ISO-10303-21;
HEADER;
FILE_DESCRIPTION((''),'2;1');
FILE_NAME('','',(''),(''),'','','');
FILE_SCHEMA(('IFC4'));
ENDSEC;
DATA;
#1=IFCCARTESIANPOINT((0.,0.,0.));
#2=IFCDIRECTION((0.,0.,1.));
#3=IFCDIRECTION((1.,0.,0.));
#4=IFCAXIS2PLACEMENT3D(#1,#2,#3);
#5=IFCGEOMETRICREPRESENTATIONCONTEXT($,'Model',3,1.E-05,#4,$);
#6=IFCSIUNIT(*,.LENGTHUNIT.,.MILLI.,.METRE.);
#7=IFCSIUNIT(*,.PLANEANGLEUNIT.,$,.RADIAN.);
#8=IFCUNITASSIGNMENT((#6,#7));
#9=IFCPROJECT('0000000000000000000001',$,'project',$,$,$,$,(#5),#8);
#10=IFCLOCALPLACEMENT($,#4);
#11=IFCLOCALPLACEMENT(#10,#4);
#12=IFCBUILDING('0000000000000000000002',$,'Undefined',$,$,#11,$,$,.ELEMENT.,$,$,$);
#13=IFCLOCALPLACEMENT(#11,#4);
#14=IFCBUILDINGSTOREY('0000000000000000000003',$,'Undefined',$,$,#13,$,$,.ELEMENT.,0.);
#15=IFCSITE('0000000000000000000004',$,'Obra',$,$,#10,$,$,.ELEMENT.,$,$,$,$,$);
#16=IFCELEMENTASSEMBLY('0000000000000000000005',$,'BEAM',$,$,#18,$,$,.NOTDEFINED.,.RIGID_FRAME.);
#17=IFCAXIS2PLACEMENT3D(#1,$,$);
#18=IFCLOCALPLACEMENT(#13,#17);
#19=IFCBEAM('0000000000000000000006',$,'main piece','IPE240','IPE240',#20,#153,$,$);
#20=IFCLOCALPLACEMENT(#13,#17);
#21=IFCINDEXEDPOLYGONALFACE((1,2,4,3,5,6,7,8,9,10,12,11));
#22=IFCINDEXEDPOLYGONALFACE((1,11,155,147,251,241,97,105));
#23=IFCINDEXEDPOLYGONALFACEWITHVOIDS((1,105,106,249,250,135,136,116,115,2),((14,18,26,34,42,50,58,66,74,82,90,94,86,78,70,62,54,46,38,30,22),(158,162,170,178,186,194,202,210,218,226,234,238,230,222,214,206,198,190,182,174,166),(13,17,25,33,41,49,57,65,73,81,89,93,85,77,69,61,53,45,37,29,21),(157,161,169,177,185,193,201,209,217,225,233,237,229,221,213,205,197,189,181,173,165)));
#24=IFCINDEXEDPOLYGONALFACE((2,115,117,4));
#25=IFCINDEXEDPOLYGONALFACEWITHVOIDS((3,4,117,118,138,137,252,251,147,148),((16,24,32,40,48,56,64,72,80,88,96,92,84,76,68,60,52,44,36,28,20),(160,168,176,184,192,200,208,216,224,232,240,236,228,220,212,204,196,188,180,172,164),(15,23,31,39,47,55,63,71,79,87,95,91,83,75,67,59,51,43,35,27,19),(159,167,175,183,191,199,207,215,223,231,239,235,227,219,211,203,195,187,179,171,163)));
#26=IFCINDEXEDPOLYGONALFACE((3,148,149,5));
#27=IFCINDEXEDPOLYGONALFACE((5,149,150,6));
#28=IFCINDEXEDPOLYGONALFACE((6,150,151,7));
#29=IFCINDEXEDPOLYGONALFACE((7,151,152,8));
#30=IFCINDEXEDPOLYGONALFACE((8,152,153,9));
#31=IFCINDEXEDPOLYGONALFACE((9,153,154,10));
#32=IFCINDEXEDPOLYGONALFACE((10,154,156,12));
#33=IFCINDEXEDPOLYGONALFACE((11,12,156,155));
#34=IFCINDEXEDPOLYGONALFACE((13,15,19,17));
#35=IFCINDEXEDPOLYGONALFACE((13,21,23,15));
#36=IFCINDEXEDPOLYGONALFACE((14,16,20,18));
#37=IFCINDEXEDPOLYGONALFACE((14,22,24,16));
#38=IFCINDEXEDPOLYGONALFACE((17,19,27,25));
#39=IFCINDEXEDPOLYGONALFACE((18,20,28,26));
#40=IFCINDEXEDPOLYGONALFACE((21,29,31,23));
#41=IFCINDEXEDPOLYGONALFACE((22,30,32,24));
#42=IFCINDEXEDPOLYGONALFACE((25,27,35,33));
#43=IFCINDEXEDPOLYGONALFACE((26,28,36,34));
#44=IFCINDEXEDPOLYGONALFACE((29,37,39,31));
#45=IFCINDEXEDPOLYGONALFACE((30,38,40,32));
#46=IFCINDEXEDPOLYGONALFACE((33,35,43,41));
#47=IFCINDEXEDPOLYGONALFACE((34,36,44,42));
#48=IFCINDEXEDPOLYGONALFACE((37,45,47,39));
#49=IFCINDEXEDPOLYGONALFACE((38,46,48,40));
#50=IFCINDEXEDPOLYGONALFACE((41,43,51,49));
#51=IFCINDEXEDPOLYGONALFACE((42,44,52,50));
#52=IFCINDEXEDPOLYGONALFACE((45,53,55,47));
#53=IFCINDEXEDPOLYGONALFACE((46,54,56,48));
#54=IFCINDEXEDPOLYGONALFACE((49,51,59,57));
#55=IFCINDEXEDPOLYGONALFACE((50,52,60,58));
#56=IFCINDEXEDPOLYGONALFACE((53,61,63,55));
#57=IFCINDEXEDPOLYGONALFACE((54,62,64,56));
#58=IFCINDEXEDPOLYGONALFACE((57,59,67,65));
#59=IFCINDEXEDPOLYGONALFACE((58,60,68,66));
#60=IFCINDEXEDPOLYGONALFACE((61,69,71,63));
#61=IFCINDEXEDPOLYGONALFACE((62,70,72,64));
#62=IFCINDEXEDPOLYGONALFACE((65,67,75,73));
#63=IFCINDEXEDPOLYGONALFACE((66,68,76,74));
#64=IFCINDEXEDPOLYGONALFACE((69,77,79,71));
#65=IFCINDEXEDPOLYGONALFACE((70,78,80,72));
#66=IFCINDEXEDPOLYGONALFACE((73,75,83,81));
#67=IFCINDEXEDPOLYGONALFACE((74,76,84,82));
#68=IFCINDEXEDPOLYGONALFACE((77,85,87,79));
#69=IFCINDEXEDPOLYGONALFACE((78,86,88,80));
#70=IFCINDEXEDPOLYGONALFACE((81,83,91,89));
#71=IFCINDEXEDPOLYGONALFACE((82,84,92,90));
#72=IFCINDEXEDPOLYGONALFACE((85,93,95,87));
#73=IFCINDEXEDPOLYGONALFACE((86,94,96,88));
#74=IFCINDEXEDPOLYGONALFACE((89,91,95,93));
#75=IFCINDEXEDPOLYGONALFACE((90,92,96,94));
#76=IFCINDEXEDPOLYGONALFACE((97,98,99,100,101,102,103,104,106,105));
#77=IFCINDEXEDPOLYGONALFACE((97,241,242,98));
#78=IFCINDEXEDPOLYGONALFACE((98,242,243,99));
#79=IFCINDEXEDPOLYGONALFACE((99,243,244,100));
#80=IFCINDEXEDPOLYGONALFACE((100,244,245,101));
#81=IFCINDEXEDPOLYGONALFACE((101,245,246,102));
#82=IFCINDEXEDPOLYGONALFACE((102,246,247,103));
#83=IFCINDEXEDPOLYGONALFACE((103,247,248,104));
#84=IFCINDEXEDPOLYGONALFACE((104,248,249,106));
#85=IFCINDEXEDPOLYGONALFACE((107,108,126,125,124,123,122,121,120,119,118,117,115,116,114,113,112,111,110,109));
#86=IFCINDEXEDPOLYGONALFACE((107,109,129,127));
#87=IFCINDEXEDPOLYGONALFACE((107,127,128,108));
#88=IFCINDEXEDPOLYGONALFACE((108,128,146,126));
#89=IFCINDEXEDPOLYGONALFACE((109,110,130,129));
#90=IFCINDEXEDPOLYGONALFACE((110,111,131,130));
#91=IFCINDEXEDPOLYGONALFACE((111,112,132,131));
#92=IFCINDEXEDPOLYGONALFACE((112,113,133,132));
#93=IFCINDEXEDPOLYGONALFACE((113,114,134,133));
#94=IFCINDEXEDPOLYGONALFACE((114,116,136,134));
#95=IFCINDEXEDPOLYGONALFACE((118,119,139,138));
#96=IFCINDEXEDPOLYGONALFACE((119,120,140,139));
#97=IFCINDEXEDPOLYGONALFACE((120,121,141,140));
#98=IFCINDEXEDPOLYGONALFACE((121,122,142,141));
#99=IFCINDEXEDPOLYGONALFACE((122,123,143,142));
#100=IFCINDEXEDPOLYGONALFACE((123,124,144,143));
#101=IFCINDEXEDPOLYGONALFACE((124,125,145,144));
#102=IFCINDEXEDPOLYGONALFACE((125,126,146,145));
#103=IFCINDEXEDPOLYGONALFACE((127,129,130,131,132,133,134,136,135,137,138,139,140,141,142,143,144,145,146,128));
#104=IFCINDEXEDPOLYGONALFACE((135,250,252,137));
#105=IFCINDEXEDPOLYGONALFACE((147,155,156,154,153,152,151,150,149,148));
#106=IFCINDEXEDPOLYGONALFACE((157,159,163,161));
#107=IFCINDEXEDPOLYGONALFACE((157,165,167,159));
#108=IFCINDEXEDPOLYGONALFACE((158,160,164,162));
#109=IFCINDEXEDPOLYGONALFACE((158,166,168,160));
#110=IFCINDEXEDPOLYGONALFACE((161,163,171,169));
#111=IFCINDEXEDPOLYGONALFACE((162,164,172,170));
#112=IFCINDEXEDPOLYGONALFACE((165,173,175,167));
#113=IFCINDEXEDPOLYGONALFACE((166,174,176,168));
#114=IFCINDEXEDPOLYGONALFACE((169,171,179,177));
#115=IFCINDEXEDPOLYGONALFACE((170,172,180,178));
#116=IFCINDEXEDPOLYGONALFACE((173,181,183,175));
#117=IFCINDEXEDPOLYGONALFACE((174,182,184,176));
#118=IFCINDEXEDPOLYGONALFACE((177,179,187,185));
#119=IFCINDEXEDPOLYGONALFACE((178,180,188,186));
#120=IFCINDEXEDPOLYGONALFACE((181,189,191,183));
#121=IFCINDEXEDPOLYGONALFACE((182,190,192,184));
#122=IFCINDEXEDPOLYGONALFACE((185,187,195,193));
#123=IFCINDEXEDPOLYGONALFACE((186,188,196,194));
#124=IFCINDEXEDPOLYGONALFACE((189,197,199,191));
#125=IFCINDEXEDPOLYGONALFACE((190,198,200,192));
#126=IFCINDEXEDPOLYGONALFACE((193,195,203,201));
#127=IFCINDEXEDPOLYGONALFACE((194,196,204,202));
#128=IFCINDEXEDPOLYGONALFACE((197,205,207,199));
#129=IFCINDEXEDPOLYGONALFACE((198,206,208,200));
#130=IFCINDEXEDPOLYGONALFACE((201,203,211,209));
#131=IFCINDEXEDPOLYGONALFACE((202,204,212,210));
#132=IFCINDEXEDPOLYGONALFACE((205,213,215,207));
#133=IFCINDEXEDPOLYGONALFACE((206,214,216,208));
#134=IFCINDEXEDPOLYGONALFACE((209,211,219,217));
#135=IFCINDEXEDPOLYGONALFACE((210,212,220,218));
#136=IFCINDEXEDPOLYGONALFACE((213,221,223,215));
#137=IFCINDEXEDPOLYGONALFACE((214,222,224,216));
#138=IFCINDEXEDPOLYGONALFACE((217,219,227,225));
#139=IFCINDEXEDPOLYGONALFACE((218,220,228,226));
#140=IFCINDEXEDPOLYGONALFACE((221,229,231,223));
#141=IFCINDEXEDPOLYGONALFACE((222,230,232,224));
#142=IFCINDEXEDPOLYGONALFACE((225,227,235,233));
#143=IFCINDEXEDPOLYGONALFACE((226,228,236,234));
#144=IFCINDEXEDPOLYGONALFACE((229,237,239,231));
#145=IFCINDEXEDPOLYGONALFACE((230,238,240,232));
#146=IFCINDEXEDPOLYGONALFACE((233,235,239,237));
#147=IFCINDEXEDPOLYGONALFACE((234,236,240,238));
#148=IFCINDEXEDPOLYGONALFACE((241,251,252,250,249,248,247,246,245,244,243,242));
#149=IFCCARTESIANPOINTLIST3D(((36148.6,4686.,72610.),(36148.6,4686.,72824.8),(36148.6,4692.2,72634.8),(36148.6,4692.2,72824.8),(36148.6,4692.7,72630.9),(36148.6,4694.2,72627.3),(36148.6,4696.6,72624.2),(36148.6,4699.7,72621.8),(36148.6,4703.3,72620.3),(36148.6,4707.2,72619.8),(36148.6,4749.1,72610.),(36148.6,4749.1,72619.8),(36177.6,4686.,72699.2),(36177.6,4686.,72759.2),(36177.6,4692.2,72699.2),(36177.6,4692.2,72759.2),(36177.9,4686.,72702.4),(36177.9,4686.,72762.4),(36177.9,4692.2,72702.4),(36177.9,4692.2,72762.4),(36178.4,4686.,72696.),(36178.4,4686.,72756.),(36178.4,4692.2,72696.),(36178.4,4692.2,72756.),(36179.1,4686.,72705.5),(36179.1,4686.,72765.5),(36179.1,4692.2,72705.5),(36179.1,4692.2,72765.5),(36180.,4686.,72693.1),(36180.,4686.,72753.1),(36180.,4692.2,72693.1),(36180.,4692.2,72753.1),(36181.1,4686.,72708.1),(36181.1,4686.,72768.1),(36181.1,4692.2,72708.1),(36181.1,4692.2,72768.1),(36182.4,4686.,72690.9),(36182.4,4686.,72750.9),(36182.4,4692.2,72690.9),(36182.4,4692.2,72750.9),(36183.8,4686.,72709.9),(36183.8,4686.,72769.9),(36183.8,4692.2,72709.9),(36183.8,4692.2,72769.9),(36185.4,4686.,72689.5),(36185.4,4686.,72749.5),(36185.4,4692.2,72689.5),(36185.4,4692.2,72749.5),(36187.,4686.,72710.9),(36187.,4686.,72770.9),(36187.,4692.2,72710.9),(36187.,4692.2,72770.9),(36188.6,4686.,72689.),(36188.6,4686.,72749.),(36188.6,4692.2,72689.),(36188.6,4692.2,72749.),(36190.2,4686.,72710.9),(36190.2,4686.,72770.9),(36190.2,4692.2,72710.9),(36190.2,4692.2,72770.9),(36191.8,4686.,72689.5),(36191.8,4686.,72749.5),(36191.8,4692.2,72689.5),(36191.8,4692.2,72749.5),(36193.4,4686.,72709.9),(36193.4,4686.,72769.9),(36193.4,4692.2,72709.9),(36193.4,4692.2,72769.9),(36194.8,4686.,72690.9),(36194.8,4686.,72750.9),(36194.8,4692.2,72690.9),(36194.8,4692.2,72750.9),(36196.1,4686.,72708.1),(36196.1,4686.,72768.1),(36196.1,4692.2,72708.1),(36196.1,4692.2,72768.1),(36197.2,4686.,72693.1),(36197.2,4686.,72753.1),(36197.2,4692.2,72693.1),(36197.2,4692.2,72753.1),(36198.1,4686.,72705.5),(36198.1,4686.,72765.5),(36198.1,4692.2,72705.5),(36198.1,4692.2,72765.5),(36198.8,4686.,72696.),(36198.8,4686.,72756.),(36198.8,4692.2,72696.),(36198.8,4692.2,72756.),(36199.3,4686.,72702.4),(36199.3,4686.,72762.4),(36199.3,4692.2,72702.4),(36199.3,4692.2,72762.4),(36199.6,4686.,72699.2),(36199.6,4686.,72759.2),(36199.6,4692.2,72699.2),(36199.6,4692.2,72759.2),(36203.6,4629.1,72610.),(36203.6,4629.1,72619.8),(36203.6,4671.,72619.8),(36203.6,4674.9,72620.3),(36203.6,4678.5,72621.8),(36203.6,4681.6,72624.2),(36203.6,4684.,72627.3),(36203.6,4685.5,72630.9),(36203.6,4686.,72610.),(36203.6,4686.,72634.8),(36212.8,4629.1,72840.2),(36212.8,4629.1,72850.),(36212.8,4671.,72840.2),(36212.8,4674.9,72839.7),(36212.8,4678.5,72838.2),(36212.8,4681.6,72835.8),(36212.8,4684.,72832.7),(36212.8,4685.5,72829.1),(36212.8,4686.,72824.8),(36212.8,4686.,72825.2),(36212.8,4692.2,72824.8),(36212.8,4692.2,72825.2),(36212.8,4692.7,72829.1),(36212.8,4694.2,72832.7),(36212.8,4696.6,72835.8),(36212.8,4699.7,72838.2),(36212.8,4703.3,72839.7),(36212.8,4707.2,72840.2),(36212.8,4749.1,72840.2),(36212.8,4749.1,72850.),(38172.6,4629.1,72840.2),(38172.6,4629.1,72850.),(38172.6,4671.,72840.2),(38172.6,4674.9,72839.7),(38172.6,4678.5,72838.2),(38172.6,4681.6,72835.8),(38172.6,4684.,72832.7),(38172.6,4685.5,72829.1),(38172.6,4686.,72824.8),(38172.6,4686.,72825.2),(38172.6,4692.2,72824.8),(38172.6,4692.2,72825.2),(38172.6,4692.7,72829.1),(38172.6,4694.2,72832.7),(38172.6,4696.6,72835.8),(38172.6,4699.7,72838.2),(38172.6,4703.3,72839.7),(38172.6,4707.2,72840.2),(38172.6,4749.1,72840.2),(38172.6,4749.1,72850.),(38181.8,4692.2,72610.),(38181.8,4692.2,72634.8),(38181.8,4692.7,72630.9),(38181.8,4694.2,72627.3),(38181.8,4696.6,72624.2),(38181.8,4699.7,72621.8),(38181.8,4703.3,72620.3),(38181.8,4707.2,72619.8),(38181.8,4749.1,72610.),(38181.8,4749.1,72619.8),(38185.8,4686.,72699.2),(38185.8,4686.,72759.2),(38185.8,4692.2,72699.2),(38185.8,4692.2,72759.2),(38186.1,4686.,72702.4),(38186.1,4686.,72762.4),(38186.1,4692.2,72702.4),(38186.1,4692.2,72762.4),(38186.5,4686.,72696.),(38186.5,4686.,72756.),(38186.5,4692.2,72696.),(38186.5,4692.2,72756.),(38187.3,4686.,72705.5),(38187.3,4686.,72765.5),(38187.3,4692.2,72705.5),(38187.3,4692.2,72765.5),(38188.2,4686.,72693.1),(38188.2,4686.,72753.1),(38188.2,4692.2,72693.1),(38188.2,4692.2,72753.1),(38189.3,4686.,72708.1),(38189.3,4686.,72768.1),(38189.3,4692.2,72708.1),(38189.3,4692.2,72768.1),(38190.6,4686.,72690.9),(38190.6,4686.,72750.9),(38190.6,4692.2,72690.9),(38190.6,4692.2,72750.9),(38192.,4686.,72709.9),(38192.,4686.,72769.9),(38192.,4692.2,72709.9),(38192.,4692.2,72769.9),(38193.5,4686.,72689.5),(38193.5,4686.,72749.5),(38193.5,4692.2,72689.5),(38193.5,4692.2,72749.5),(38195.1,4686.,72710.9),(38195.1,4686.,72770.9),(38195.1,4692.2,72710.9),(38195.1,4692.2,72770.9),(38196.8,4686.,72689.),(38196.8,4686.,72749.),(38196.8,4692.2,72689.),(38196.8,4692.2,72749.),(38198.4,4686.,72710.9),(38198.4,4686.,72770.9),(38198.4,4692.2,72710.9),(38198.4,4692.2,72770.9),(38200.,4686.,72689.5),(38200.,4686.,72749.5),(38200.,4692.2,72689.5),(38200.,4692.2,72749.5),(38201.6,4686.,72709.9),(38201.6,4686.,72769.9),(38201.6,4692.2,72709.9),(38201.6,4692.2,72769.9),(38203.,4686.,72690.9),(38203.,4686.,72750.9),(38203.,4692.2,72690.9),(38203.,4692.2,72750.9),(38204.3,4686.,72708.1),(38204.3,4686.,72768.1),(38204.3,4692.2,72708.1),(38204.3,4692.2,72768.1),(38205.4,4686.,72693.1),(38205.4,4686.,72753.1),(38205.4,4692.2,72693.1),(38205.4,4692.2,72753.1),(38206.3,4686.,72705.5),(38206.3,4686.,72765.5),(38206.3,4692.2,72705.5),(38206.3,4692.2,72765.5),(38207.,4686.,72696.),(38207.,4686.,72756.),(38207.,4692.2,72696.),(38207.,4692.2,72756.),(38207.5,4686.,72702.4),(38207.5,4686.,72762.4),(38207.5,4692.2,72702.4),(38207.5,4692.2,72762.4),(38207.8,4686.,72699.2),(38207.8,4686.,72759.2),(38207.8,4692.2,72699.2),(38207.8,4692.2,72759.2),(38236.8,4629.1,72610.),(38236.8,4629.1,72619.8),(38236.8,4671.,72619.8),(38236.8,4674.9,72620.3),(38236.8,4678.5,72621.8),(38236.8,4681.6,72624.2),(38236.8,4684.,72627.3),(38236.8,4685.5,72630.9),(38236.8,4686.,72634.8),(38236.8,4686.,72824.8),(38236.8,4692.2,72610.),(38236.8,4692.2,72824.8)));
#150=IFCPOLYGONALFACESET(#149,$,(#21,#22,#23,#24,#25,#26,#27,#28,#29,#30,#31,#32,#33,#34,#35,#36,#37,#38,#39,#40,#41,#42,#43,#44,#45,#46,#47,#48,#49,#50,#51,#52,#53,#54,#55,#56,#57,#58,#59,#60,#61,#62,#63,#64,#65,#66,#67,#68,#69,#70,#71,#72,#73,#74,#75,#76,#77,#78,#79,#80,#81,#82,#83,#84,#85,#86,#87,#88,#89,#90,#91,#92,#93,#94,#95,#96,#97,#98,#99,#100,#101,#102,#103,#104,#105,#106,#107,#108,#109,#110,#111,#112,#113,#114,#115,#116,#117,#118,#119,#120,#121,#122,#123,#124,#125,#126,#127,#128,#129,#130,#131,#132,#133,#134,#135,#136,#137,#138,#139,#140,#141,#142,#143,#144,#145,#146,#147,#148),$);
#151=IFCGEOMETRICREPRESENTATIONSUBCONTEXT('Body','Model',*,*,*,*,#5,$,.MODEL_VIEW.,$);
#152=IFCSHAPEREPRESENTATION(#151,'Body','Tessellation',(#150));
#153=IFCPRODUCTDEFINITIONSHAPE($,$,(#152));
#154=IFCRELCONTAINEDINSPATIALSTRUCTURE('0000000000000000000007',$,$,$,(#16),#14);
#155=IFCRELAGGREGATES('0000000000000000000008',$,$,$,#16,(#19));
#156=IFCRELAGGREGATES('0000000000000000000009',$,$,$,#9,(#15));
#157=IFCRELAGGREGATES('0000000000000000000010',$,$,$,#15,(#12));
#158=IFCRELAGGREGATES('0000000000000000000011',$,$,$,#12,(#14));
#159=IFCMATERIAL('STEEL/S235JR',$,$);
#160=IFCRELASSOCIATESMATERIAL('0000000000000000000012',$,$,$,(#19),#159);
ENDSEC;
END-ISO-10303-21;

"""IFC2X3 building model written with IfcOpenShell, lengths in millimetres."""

from ifc_helpers import new_model, si_unit, frame, origin_with_axes, origin_2d_with_axis, place, context, subcontext, project, spatial, rectangle, circle, i_section, extrude, clip, halfspace, source, transform, mapped, material, element, aggregate, save


model = new_model("IFC2X3")

# Units and contexts
model_context = context("Model", 3, precision=1e-05, world=origin_with_axes())
body_context = subcontext(model_context, "Body", "Model", "MODEL_VIEW")
ifc_project = project(units=[si_unit("LENGTHUNIT", "METRE", prefix="MILLI"), si_unit("PLANEANGLEUNIT", "RADIAN")], contexts=[model_context])

# Site, building, storey
site_placement = place(None, origin_with_axes())
site = spatial("IfcSite", under=ifc_project, at=site_placement, Name="Obra", CompositionType="ELEMENT")
building_placement = place(site_placement, origin_with_axes())
building = spatial("IfcBuilding", under=site, at=building_placement, Name="Undefined", CompositionType="ELEMENT")
storey_placement = place(building_placement, origin_with_axes())
storey = spatial("IfcBuildingStorey", under=building, at=storey_placement, Name="Undefined", CompositionType="ELEMENT", Elevation=0.0)

# Element assembly, beam, openings
ifc_material_1 = material(Name="STEEL/S235JR")
shared_shape_1 = source(origin_with_axes(), body_context, "Body", "SweptSolid", [
    extrude(circle(Radius=11.0, at=origin_2d_with_axis()), frame((0.0, -3.2, 0.0), z_axis=(0.0, 1.0, 0.0), x_axis=(1.0, 0.0, 0.0)), (0.0, 0.0, 1.0), 6.4),
])
assembly_1_placement = place(storey_placement, origin_with_axes())
assembly_1 = element("IfcElementAssembly", 1, at=assembly_1_placement, inside=storey, Name="BEAM", AssemblyPlace="NOTDEFINED", PredefinedType="RIGID_FRAME")
beam_1_placement = place(assembly_1_placement, frame((38169.8, 4689.1, 72730.0), z_axis=(0.0, 0.0, 1.0), x_axis=(-1.0, 0.0, 0.0)))
beam_1 = element("IfcBeam", 2, at=beam_1_placement, material=ifc_material_1, Name="main piece", Description="IPE240", ObjectType="IPE240", context=body_context, shape_type="Clipping", body=[
    clip(clip(extrude(i_section(OverallWidth=120.0, OverallDepth=240.0, WebThickness=6.2, FlangeThickness=9.8, FilletRadius=15.0, at=origin_2d_with_axis()), frame((2021.2, 0.0, 0.0), z_axis=(-1.0, 0.0, 0.0), x_axis=(0.0, -1.0, 0.0)), (0.0, 0.0, 1.0), 2088.2), halfspace(frame((2021.2, 0.0, -220.0), z_axis=(-1.0, 0.0, 0.0), x_axis=(0.0, 1.0, 0.0)), True)), halfspace(frame((-66.9, 0.0, -220.0), z_axis=(1.0, 0.0, 0.0), x_axis=(0.0, -1.0, 0.0)), True)),
])
opening_1_placement = place(assembly_1_placement, frame((38169.8, 4689.1, 72730.0), z_axis=(0.0, 0.0, 1.0), x_axis=(-1.0, 0.0, 0.0)))
element("IfcOpeningElement", 3, at=opening_1_placement, cuts=beam_1, ObjectType="Recess", context=body_context, shape_type="SweptSolid", body=[
    extrude(rectangle(XDim=65.0, YDim=300.0, at=origin_2d_with_axis()), frame((-44.4, -153.1, 109.8), z_axis=(0.0, 0.0, -1.0), x_axis=(1.0, 0.0, 0.0)), (0.0, 0.0, 1.0), 249.6),
])
opening_2_placement = place(assembly_1_placement, frame((38169.8, 4689.1, 72730.0), z_axis=(0.0, 0.0, 1.0), x_axis=(-1.0, 0.0, 0.0)))
element("IfcOpeningElement", 4, at=opening_2_placement, cuts=beam_1, ObjectType="Recess", context=body_context, shape_type="SweptSolid", body=[
    extrude(rectangle(XDim=26.2, YDim=76.2, at=origin_2d_with_axis()), frame((-40.8, -61.0, 107.9), z_axis=(0.0, 1.0, 0.0), x_axis=(0.0, 0.0, -1.0)), (0.0, 0.0, 1.0), 122.0),
])
opening_3_placement = place(assembly_1_placement, frame((38169.8, 4689.1, 72730.0), z_axis=(0.0, 0.0, 1.0), x_axis=(-1.0, 0.0, 0.0)))
element("IfcOpeningElement", 5, at=opening_3_placement, cuts=beam_1, ObjectType="Recess", context=body_context, shape_type="SweptSolid", body=[
    extrude(rectangle(XDim=65.0, YDim=300.0, at=origin_2d_with_axis()), frame((1998.7, 153.1, 109.8), z_axis=(0.0, 0.0, -1.0), x_axis=(-1.0, 0.0, 0.0)), (0.0, 0.0, 1.0), 249.6),
])
opening_4_placement = place(assembly_1_placement, frame((38169.8, 4689.1, 72730.0), z_axis=(0.0, 0.0, 1.0), x_axis=(-1.0, 0.0, 0.0)))
element("IfcOpeningElement", 6, at=opening_4_placement, cuts=beam_1, ObjectType="Recess", context=body_context, shape_type="SweptSolid", body=[
    extrude(rectangle(XDim=26.2, YDim=76.2, at=origin_2d_with_axis()), frame((1995.1, 61.0, 107.9), z_axis=(0.0, -1.0, 0.0), x_axis=(0.0, 0.0, -1.0)), (0.0, 0.0, 1.0), 122.0),
])
opening_5_placement = place(assembly_1_placement, frame((38236.8, 4689.1, 72850.0), z_axis=(-1.0, 0.0, 0.0), x_axis=(0.0, 0.0, -1.0)))
element("IfcOpeningElement", 7, at=opening_5_placement, cuts=beam_1, ObjectType="Opening", context=body_context, shape_type="MappedRepresentation", body=[
    mapped(shared_shape_1, transform((90.0, 0.0, 40.0))),
    mapped(shared_shape_1, transform((150.0, 0.0, 40.0))),
])
opening_6_placement = place(assembly_1_placement, frame((36148.6, 4689.1, 72850.0), z_axis=(1.0, 0.0, 0.0), x_axis=(0.0, 0.0, -1.0)))
element("IfcOpeningElement", 8, at=opening_6_placement, cuts=beam_1, ObjectType="Opening", context=body_context, shape_type="MappedRepresentation", body=[
    mapped(shared_shape_1, transform((90.0, 0.0, 40.0))),
    mapped(shared_shape_1, transform((150.0, 0.0, 40.0))),
])
aggregate(assembly_1, [beam_1])

save(model, "model.ifc")
